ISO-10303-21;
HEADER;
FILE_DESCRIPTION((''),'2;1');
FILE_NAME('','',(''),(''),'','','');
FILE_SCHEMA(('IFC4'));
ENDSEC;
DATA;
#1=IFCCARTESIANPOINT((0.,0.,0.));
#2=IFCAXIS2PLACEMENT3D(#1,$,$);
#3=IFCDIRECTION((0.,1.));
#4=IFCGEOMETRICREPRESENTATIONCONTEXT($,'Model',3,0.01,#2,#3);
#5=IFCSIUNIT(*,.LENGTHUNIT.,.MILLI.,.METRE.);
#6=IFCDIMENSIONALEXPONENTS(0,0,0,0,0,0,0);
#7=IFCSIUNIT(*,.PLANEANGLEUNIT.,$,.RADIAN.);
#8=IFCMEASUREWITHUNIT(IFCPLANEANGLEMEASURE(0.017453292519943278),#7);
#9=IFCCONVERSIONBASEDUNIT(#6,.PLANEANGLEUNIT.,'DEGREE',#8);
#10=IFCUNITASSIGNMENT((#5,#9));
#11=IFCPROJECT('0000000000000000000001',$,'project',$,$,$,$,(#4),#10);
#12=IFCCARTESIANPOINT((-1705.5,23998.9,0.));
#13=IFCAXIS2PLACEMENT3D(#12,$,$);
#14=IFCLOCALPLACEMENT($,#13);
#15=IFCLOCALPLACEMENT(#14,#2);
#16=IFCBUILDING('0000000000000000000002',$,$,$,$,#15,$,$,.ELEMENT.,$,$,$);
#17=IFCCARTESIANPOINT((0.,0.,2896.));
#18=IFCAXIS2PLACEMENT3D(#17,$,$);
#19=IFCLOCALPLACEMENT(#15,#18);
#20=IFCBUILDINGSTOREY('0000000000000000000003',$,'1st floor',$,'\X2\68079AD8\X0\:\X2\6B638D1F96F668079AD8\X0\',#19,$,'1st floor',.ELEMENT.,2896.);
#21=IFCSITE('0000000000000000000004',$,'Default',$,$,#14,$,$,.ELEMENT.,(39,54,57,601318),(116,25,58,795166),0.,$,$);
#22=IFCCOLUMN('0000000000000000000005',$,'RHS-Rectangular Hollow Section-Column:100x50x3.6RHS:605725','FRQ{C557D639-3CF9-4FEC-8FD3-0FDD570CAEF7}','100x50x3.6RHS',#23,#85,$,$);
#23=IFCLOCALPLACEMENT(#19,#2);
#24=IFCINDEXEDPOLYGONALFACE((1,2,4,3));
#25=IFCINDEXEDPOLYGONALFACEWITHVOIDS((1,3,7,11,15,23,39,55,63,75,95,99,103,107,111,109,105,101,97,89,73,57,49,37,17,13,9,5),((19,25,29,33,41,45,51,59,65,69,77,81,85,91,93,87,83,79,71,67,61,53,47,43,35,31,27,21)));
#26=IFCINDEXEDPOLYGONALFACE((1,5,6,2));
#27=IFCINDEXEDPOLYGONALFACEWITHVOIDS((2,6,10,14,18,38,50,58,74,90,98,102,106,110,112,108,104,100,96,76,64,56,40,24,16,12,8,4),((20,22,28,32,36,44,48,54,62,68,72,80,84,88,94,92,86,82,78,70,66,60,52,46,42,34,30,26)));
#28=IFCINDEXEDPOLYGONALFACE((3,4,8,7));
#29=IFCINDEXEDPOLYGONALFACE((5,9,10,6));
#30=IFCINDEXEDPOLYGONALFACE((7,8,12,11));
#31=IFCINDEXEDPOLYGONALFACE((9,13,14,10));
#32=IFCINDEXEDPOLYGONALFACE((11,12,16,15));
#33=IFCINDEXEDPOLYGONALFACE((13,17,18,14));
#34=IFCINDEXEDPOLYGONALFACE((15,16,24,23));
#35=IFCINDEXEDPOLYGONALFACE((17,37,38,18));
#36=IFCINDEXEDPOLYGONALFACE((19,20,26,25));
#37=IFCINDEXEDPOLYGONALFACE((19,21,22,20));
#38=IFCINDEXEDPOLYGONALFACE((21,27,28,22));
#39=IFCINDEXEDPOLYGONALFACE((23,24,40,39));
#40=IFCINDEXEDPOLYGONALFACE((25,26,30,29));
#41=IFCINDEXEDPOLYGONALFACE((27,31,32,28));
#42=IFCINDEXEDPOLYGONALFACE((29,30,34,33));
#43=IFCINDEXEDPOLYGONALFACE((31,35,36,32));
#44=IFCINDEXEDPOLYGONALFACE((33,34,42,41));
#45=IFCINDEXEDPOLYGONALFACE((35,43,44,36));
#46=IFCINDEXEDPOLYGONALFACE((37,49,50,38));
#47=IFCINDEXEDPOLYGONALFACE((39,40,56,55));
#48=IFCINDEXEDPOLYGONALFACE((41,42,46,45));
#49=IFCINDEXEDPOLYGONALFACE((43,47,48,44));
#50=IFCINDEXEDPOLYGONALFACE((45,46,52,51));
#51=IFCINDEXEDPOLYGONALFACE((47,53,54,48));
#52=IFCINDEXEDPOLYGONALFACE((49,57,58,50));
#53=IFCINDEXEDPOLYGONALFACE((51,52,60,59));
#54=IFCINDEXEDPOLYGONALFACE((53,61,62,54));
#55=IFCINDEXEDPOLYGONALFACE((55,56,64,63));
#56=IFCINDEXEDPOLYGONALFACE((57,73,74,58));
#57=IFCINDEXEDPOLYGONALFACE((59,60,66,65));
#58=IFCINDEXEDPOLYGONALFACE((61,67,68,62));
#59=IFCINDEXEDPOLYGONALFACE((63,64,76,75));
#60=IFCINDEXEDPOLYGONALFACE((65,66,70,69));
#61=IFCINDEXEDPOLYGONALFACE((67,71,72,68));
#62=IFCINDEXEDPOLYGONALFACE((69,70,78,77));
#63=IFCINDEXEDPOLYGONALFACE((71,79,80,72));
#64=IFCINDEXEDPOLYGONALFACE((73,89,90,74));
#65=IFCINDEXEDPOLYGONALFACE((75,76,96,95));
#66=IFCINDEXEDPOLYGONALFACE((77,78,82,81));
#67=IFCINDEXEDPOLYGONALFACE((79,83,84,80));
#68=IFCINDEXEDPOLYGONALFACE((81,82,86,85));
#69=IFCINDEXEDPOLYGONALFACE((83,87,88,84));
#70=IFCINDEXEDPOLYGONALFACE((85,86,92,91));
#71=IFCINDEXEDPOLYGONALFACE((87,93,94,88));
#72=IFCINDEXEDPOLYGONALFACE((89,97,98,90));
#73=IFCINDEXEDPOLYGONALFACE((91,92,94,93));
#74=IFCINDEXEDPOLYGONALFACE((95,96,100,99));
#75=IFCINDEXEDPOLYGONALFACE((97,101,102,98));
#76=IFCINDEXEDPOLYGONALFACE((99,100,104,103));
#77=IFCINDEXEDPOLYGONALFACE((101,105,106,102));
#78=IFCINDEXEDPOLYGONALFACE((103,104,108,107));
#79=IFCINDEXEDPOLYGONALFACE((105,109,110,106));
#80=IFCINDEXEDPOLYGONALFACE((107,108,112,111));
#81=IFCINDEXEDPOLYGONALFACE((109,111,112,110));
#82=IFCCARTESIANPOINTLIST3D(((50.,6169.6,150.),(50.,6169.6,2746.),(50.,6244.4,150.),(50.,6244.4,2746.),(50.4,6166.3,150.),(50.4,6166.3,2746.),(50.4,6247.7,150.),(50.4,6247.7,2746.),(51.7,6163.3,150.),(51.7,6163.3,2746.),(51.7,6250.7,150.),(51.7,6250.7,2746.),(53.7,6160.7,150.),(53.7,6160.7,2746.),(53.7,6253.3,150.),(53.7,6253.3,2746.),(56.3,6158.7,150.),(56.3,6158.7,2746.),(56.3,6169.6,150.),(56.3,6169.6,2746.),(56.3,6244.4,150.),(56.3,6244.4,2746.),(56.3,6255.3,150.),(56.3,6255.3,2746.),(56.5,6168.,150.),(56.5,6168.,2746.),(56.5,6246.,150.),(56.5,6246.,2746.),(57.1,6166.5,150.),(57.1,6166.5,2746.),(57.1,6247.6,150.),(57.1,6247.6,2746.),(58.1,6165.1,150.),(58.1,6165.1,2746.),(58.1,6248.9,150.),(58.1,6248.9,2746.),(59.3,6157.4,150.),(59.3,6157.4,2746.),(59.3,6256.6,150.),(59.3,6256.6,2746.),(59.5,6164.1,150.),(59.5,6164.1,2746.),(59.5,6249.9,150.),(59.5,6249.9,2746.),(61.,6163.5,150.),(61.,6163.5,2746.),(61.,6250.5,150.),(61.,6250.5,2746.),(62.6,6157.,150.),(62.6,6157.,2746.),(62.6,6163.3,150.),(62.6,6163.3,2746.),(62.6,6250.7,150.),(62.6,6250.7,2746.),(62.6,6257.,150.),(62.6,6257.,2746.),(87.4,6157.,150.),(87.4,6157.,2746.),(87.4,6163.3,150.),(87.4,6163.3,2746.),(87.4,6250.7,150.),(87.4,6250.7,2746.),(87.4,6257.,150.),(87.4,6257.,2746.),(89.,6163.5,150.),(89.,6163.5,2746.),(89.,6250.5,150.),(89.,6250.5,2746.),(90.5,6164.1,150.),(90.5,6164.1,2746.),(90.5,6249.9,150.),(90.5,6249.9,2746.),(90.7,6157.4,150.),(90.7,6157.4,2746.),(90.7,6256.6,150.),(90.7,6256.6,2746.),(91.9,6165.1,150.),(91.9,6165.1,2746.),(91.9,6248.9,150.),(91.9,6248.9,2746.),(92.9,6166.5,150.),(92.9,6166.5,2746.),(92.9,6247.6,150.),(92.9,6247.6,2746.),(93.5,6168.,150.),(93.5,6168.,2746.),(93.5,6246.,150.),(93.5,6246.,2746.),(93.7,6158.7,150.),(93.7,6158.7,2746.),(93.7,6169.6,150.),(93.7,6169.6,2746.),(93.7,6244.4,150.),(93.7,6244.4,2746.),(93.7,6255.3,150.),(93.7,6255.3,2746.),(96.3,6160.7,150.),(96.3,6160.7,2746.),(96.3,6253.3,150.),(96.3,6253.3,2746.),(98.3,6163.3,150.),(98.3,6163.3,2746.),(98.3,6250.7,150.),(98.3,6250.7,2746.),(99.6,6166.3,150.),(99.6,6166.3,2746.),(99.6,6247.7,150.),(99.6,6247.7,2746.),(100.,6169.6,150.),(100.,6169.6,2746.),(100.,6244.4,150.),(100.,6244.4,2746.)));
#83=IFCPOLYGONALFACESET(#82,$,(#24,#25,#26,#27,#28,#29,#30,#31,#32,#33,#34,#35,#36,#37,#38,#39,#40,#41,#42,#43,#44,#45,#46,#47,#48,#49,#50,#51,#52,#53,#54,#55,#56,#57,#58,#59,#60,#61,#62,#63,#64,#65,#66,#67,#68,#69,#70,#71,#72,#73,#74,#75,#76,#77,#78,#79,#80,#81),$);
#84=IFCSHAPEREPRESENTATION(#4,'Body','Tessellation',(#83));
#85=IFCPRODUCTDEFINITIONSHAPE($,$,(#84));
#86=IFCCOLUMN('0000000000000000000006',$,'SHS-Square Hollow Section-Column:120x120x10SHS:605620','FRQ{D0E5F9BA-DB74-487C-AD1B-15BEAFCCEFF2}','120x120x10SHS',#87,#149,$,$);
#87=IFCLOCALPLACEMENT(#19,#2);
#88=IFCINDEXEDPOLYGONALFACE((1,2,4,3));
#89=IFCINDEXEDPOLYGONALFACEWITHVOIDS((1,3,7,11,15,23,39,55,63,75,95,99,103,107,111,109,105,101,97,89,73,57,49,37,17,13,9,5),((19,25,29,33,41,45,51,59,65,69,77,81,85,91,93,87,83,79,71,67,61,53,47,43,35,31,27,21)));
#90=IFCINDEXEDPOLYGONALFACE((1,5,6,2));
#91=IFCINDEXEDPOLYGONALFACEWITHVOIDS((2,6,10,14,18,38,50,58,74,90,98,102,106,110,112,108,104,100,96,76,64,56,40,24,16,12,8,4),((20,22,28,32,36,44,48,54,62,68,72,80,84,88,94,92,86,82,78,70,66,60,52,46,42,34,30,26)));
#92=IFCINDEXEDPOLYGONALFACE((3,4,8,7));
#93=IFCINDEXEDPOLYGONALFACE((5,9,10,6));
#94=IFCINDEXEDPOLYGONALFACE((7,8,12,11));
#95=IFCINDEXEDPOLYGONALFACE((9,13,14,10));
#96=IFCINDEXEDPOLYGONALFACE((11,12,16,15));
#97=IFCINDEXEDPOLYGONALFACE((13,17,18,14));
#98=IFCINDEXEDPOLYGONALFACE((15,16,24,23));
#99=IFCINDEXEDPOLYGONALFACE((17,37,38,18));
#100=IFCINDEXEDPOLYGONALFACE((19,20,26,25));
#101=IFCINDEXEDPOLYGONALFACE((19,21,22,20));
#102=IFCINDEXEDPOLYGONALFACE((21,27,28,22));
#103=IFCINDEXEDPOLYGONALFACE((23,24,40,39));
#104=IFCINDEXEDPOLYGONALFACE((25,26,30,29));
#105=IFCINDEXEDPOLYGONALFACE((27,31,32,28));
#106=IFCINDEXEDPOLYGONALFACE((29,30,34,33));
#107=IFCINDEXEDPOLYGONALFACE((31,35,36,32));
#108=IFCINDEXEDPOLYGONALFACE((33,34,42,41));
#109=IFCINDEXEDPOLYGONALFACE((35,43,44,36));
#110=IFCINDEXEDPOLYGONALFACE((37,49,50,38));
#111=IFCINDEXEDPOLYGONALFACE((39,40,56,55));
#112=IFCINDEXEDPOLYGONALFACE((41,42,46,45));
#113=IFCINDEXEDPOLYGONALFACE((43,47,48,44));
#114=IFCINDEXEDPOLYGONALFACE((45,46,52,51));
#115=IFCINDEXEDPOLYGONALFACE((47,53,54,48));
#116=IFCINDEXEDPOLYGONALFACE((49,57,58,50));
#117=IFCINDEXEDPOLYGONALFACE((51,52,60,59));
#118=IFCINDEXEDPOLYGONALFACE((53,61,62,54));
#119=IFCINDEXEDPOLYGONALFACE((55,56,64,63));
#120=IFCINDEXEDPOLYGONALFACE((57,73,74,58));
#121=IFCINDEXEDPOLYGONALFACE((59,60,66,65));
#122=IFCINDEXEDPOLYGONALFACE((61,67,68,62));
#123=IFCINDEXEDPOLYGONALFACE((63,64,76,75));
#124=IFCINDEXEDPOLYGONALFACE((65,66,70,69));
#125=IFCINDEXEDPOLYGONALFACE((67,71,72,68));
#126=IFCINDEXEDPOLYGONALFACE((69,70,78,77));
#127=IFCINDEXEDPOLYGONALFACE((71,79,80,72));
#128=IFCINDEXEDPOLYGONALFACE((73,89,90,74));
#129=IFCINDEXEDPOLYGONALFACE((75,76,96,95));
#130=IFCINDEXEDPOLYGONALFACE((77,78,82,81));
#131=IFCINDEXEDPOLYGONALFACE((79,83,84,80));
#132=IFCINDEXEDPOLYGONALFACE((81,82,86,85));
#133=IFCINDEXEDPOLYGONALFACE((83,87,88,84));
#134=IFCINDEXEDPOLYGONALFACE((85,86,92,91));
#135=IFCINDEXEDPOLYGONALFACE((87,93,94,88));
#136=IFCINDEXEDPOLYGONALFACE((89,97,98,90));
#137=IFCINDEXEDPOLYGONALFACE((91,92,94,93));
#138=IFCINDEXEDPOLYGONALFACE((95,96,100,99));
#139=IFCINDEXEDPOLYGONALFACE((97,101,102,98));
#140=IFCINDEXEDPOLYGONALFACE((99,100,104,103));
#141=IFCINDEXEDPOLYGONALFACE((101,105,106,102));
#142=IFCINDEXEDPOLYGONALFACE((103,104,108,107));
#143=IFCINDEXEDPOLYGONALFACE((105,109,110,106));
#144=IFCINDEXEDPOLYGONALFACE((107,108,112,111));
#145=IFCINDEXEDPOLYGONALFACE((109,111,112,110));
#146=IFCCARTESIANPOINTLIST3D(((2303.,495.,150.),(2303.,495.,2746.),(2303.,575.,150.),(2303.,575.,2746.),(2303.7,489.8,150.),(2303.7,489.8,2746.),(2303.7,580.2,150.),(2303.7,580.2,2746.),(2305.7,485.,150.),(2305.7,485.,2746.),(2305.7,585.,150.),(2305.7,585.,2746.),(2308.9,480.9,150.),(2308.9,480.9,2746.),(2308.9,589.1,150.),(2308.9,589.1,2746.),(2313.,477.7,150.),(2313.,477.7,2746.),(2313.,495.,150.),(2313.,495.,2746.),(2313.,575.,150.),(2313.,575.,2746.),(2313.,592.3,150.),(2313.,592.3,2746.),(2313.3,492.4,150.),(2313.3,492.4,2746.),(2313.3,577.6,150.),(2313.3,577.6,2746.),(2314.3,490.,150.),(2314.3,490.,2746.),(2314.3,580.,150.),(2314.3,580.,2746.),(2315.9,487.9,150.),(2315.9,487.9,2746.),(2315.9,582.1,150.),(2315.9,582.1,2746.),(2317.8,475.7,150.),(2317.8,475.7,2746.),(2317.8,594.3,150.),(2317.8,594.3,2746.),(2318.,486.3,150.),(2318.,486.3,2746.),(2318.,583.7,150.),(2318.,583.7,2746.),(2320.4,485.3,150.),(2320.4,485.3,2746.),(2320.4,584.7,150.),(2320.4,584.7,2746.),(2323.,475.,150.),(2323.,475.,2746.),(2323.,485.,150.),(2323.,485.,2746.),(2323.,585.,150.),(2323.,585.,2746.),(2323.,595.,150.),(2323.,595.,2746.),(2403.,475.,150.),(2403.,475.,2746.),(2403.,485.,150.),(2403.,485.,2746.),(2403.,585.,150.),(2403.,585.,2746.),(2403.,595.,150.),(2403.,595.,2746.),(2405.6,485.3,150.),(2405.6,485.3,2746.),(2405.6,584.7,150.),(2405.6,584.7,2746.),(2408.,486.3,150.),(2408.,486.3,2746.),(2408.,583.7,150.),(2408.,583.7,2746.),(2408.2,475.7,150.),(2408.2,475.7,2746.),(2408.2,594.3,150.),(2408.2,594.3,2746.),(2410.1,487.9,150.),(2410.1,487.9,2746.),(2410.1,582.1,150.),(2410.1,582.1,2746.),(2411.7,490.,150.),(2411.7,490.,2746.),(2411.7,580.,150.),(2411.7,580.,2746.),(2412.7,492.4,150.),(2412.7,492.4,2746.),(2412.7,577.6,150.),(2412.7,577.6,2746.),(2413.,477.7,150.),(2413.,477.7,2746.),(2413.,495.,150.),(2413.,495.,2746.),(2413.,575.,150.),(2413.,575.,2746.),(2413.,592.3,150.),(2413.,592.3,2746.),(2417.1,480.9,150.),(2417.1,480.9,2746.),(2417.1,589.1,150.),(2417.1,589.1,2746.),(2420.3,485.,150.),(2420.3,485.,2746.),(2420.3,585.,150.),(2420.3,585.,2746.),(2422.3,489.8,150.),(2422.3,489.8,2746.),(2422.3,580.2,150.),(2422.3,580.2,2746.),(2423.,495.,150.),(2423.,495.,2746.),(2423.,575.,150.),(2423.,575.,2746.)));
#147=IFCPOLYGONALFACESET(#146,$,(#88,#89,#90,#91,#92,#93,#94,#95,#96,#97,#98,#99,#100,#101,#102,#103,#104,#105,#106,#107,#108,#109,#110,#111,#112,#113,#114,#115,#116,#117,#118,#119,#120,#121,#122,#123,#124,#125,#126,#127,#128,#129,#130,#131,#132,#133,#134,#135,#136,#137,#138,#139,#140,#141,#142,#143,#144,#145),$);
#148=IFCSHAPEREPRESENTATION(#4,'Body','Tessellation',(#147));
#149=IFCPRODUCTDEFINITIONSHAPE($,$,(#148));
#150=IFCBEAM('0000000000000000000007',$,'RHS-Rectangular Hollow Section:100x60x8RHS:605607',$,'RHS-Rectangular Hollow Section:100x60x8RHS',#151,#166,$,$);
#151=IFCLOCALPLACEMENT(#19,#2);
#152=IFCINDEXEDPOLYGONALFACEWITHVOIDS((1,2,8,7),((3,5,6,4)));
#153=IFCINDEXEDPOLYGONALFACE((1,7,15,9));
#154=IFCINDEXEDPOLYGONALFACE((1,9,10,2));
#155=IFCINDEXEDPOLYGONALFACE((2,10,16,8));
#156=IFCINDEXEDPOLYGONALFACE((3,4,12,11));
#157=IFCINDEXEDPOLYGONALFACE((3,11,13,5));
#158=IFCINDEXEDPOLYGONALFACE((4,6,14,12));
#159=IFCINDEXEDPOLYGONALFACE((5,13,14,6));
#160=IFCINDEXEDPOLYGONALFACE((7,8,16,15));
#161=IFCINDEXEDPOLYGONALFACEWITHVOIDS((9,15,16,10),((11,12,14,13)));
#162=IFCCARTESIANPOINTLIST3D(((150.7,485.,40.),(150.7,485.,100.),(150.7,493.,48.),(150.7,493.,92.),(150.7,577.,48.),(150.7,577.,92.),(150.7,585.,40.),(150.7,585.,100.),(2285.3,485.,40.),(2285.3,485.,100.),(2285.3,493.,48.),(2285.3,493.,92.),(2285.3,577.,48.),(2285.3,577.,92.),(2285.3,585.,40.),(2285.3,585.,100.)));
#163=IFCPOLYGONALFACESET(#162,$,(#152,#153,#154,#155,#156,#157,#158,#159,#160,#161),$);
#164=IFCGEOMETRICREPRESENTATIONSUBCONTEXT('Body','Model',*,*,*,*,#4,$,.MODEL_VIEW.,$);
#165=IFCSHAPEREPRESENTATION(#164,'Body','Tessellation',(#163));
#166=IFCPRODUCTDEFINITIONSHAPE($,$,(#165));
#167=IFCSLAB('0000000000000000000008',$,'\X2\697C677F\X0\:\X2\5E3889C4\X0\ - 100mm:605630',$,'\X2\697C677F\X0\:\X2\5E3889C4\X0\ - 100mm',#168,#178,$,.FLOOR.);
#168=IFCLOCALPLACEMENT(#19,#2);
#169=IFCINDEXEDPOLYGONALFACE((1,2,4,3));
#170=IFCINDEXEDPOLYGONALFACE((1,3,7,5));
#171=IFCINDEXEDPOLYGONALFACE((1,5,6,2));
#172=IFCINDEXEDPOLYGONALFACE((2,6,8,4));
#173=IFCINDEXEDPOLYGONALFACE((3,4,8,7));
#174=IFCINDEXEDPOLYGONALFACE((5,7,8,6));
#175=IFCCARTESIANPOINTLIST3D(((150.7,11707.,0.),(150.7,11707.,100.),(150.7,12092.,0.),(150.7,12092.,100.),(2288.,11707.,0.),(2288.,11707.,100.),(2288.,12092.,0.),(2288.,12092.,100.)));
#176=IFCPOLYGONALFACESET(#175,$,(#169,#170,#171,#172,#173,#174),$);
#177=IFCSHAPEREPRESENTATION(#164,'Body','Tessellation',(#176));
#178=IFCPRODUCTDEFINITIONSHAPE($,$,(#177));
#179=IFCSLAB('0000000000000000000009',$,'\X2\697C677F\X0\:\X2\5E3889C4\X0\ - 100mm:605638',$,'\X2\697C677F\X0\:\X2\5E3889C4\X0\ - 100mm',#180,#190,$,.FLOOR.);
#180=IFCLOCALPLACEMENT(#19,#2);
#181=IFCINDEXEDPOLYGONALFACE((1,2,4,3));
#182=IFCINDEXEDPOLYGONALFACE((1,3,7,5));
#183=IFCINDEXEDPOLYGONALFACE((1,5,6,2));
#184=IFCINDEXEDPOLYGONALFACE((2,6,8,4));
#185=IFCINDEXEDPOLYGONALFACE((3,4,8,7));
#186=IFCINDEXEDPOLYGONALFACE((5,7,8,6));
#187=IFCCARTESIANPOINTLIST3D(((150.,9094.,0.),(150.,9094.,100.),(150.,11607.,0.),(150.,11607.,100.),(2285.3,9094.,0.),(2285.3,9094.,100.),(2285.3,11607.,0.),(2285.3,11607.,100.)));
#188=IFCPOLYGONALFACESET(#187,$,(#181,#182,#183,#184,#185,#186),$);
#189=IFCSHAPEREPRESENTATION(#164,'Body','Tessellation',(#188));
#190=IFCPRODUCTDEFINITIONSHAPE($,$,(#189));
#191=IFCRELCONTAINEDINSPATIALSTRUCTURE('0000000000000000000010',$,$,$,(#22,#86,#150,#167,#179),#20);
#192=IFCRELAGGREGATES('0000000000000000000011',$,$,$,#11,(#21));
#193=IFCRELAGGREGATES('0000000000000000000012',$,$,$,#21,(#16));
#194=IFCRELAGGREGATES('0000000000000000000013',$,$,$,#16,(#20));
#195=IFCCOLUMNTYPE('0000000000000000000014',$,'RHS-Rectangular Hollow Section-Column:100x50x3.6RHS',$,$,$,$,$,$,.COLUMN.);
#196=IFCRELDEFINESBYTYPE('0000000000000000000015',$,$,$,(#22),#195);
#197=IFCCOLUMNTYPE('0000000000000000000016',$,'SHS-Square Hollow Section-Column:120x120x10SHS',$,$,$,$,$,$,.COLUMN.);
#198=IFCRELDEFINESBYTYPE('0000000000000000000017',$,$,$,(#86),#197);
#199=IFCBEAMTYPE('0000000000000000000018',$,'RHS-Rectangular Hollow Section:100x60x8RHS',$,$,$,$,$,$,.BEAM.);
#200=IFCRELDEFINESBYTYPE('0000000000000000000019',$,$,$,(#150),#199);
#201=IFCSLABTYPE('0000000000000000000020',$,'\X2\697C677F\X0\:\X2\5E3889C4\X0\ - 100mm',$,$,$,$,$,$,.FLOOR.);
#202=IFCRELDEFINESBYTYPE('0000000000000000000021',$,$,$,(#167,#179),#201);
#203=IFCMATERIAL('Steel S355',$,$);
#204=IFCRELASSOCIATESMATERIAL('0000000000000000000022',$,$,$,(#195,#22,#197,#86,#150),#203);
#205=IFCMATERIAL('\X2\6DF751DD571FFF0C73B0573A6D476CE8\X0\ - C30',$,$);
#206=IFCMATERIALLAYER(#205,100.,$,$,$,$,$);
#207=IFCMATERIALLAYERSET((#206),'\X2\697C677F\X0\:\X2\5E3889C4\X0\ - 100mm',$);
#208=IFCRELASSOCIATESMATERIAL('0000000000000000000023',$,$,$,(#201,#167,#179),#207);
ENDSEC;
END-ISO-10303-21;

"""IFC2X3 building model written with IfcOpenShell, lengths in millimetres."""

from ifc_helpers import new_model, entity, si_unit, converted_unit, direction, frame, frame_2d, origin, origin_2d, origin_2d_with_axis, place, context, subcontext, project, spatial, rectangle, hollow_rectangle, extrude, boolean, clip, halfspace, material, layer, layer_set, layer_usage, type_object, element, save


model = new_model("IFC2X3")

# Units and contexts
model_context = context("Model", 3, precision=0.01, world=origin(), true_north=direction((0.0, 1.0)))
body_context = subcontext(model_context, "Body", "Model", "MODEL_VIEW")
ifc_project = project(units=[si_unit("LENGTHUNIT", "METRE", prefix="MILLI"), converted_unit("PLANEANGLEUNIT", "DEGREE", entity("IfcPlaneAngleMeasure", 0.017453292519943278), si_unit("PLANEANGLEUNIT", "RADIAN"), dimensions=[0, 0, 0, 0, 0, 0, 0])], contexts=[model_context])

# Site, building, storey
site_placement = place(None, frame((-1705.5, 23998.9, 0.0)))
site = spatial("IfcSite", under=ifc_project, at=site_placement, Name="Default", CompositionType="ELEMENT", RefLatitude=(39, 54, 57, 601318), RefLongitude=(116, 25, 58, 795166), RefElevation=0.0)
building_placement = place(site_placement, origin())
building = spatial("IfcBuilding", under=site, at=building_placement, CompositionType="ELEMENT")
storey_placement = place(building_placement, frame((0.0, 0.0, 2896.0)))
storey = spatial("IfcBuildingStorey", under=building, at=storey_placement, Name="1st floor", ObjectType="标高:正负零标高", LongName="1st floor", CompositionType="ELEMENT", Elevation=2896.0)

# Shared definitions
ifc_material_1 = material(Name="Steel S355")

# Columns
column_type_1 = type_object("IfcColumnType", Name="RHS-Rectangular Hollow Section-Column:100x50x3.6RHS", PredefinedType="COLUMN", material=ifc_material_1)
column_1_placement = place(storey_placement, frame((75.0, 6207.0, 2746.0), z_axis=(0.0, 0.0, 1.0), x_axis=(-1.0, 0.0, 0.0)))
element("IfcColumn", 1, at=column_1_placement, inside=storey, type_object=column_type_1, material=ifc_material_1, Name="RHS-Rectangular Hollow Section-Column:100x50x3.6RHS:605725", Description="FRQ{C557D639-3CF9-4FEC-8FD3-0FDD570CAEF7}", ObjectType="100x50x3.6RHS", context=model_context, shape_type="Clipping", body=[
    clip(extrude(hollow_rectangle(XDim=50.0, YDim=100.0, WallThickness=6.3, InnerFilletRadius=6.3, OuterFilletRadius=12.6, at=origin_2d()), origin(), (0.0, 0.0, -1.0), 2651.9), halfspace(frame((75.0, 6207.0, -2596.0), z_axis=(0.0, 0.0, 1.0), x_axis=(-1.0, 0.0, 0.0)), True)),
])
column_type_2 = type_object("IfcColumnType", Name="SHS-Square Hollow Section-Column:120x120x10SHS", PredefinedType="COLUMN", material=ifc_material_1)
column_2_placement = place(storey_placement, frame((2363.0, 535.0, 2746.0), z_axis=(0.0, 0.0, 1.0), x_axis=(0.0, -1.0, 0.0)))
element("IfcColumn", 2, at=column_2_placement, inside=storey, type_object=column_type_2, material=ifc_material_1, Name="SHS-Square Hollow Section-Column:120x120x10SHS:605620", Description="FRQ{D0E5F9BA-DB74-487C-AD1B-15BEAFCCEFF2}", ObjectType="120x120x10SHS", context=model_context, shape_type="Clipping", body=[
    clip(extrude(hollow_rectangle(XDim=120.0, YDim=120.0, WallThickness=10.0, InnerFilletRadius=10.0, OuterFilletRadius=20.0, at=origin_2d()), origin(), (0.0, 0.0, -1.0), 2680.9), halfspace(frame((535.0, -2363.0, -2596.0), z_axis=(0.0, 0.0, 1.0), x_axis=(0.0, 1.0, 0.0)), True)),
])

# Beam
beam_type_1 = type_object("IfcBeamType", Name="RHS-Rectangular Hollow Section:100x60x8RHS", PredefinedType="BEAM")
beam_1_placement = place(storey_placement, frame((150.7, 585.0, 70.0)))
element("IfcBeam", 3, at=beam_1_placement, inside=storey, type_object=beam_type_1, material=ifc_material_1, Name="RHS-Rectangular Hollow Section:100x60x8RHS:605607", ObjectType="RHS-Rectangular Hollow Section:100x60x8RHS", context=body_context, shape_type="SweptSolid", body=[
    boolean("DIFFERENCE", extrude(rectangle(XDim=60.0, YDim=100.0, at=frame_2d((0.0, 0.0), x_axis=(1.0, 0.0))), frame((0.0, -50.0, 0.0), z_axis=(1.0, 0.0, 0.0), x_axis=(0.0, 0.0, -1.0)), (0.0, 0.0, 1.0), 2134.6), extrude(rectangle(XDim=44.0, YDim=84.0, at=frame_2d((0.0, 0.0), x_axis=(0.0, 1.0))), frame((2134.6, -50.0, 0.0), z_axis=(-1.0, 0.0, 0.0), x_axis=(0.0, 1.0, 0.0)), (0.0, 0.0, 1.0), 2134.6)),
])

# Slabs
ifc_material_2 = material(Name="混凝土，现场浇注 - C30")
ifc_layer_1 = layer(ifc_material_2, 100.0)
ifc_layer_set_1 = layer_set([ifc_layer_1], Name="楼板:常规 - 100mm")
ifc_layer_usage_1 = layer_usage(ifc_layer_set_1, "AXIS3", "POSITIVE", 0.0)
slab_type = type_object("IfcSlabType", Name="楼板:常规 - 100mm", PredefinedType="FLOOR", material=ifc_layer_set_1)
slab_1_placement = place(storey_placement, origin())
element("IfcSlab", 4, at=slab_1_placement, inside=storey, type_object=slab_type, material=ifc_layer_usage_1, Name="楼板:常规 - 100mm:605630", ObjectType="楼板:常规 - 100mm", PredefinedType="FLOOR", context=body_context, shape_type="SweptSolid", body=[
    extrude(rectangle(XDim=385.0, YDim=2137.3, at=origin_2d_with_axis()), frame((1219.3, 11899.5, 100.0), z_axis=(0.0, 0.0, -1.0), x_axis=(0.0, 1.0, 0.0)), (0.0, 0.0, 1.0), 100.0),
])
ifc_layer_usage_2 = layer_usage(ifc_layer_set_1, "AXIS3", "POSITIVE", 0.0)
slab_2_placement = place(storey_placement, origin())
element("IfcSlab", 5, at=slab_2_placement, inside=storey, type_object=slab_type, material=ifc_layer_usage_2, Name="楼板:常规 - 100mm:605638", ObjectType="楼板:常规 - 100mm", PredefinedType="FLOOR", context=body_context, shape_type="SweptSolid", body=[
    extrude(rectangle(XDim=2513.0, YDim=2135.3, at=frame_2d((0.0, 0.0), x_axis=(1.0, 0.0))), frame((1217.6, 10350.5, 100.0), z_axis=(0.0, 0.0, -1.0), x_axis=(0.0, 1.0, 0.0)), (0.0, 0.0, 1.0), 100.0),
])

save(model, "model.ifc")
